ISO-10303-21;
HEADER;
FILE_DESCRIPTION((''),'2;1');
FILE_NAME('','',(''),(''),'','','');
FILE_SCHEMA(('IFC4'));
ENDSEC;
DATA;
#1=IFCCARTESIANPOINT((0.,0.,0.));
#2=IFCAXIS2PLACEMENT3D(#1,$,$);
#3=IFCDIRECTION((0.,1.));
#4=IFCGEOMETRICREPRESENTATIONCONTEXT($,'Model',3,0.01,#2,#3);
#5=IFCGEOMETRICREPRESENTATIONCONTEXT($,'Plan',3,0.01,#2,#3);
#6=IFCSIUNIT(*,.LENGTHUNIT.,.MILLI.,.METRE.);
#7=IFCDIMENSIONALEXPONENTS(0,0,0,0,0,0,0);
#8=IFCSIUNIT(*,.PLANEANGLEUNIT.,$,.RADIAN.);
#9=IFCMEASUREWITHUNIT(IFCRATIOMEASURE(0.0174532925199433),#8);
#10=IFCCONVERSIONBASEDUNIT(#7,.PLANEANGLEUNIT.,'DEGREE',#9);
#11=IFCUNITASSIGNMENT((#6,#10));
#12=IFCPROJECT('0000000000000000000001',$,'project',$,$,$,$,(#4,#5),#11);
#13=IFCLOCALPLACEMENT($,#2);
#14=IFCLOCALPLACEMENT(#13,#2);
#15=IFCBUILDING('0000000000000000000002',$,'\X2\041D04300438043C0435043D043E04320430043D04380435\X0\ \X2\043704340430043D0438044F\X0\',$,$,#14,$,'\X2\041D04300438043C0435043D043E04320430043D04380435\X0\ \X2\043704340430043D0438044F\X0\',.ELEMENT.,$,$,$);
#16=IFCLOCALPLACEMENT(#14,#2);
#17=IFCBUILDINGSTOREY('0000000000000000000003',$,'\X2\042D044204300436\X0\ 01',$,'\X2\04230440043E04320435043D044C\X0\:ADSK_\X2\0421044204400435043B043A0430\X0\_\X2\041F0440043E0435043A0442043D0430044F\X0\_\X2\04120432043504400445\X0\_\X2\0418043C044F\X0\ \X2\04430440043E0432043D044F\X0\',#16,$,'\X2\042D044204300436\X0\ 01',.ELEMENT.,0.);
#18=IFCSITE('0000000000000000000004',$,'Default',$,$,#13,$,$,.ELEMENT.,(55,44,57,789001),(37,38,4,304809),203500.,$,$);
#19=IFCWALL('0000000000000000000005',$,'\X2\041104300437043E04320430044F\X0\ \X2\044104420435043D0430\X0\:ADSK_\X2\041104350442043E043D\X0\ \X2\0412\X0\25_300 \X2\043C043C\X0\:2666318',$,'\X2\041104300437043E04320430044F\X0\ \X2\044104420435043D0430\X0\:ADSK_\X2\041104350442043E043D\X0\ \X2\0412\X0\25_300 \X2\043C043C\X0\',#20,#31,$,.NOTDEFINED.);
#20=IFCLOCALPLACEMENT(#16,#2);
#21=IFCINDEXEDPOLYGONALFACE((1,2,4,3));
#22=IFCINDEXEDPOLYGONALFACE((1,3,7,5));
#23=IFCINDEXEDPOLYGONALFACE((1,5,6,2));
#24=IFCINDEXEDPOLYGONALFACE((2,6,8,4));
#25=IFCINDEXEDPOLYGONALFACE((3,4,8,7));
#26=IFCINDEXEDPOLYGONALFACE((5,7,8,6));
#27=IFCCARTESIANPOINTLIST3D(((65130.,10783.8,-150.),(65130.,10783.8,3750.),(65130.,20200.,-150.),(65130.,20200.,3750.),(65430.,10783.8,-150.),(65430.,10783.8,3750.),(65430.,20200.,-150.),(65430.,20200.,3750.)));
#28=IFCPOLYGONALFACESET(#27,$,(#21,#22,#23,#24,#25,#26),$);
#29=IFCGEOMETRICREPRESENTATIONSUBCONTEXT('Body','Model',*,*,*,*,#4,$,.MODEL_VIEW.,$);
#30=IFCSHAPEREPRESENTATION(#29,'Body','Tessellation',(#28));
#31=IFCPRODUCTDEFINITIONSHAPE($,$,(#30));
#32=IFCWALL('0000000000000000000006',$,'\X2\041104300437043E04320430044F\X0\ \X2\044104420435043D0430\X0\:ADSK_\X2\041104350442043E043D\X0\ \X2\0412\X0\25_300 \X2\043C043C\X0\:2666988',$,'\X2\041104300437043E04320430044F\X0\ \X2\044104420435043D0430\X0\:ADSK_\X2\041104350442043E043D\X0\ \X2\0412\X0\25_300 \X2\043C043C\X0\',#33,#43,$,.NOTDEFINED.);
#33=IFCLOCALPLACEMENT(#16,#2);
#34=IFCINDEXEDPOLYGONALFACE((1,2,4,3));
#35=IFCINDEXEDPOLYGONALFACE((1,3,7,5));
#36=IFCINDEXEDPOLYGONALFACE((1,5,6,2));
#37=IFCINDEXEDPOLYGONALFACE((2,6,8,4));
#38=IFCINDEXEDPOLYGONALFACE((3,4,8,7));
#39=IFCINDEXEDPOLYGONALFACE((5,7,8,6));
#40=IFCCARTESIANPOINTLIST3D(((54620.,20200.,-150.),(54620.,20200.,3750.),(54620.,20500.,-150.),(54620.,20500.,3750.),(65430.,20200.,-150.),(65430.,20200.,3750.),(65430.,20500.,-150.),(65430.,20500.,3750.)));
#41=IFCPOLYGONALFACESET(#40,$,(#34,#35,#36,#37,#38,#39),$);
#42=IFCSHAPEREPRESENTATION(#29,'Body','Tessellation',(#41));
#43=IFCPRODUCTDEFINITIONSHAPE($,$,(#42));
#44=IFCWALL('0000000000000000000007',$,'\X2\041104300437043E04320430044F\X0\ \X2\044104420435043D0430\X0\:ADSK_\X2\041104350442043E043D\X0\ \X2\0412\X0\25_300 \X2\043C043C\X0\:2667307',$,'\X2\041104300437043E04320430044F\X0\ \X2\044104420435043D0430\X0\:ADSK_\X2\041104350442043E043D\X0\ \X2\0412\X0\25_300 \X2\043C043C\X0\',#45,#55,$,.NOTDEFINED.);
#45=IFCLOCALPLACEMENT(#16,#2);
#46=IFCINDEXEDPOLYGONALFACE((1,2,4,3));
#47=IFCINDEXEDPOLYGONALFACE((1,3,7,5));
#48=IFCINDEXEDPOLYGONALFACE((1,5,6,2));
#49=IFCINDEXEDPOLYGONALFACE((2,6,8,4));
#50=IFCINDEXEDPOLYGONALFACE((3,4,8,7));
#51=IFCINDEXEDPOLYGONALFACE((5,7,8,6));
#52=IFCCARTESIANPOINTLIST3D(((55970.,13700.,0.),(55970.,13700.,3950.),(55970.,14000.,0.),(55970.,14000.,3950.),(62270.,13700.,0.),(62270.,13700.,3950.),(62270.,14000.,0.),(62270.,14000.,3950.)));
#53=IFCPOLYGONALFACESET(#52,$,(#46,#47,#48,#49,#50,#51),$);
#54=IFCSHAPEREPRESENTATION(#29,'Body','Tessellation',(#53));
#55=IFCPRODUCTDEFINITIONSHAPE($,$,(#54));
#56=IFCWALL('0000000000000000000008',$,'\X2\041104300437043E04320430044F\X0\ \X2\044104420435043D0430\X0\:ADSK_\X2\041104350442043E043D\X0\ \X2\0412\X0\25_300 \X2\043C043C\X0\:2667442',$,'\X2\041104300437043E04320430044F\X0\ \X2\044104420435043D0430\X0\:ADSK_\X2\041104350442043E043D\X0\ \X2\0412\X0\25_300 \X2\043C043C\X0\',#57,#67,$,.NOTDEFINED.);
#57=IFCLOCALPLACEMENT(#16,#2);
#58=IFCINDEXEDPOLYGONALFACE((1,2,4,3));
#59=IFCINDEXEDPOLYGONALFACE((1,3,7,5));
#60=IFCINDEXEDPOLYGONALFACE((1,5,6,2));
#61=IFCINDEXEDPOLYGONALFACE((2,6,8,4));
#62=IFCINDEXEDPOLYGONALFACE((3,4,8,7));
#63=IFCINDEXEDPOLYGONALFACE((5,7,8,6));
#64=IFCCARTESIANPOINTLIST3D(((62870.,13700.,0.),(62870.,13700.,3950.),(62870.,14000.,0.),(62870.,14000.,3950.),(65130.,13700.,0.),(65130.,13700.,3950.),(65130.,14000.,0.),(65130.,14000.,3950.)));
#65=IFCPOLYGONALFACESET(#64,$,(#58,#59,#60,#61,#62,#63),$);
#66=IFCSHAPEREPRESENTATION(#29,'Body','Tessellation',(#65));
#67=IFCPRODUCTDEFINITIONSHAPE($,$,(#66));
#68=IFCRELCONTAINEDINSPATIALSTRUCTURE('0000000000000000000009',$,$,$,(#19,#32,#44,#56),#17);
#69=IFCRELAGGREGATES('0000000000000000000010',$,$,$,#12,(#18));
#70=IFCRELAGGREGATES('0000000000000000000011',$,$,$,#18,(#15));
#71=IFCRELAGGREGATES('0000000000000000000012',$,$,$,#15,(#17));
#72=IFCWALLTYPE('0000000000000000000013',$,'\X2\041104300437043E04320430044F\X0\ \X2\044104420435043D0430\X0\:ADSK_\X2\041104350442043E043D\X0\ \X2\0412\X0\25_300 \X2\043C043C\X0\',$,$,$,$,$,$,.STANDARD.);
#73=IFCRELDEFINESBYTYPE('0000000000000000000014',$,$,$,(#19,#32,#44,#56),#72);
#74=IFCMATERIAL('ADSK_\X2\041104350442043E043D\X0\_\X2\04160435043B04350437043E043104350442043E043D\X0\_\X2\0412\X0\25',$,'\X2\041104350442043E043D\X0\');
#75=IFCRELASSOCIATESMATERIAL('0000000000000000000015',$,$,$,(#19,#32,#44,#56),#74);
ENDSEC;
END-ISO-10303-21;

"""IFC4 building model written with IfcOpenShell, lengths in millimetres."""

from ifc_helpers import new_model, entity, si_unit, converted_unit, direction, frame, origin, place, context, subcontext, project, spatial, indexed_curve, outline, extrude, material, type_object, element, save


model = new_model("IFC4")

# Units and contexts
model_context = context("Model", 3, precision=0.01, world=origin(), true_north=direction((0.0, 1.0)))
plan_context = context("Plan", 3, precision=0.01, world=origin(), true_north=direction((0.0, 1.0)))
body_context = subcontext(model_context, "Body", "Model", "MODEL_VIEW")
ifc_project = project(units=[si_unit("LENGTHUNIT", "METRE", prefix="MILLI"), converted_unit("PLANEANGLEUNIT", "DEGREE", entity("IfcRatioMeasure", 0.0174532925199433), si_unit("PLANEANGLEUNIT", "RADIAN"), dimensions=[0, 0, 0, 0, 0, 0, 0])], contexts=[model_context, plan_context])

# Site, building, storey
site_placement = place(None, origin())
site = spatial("IfcSite", under=ifc_project, at=site_placement, Name="Default", CompositionType="ELEMENT", RefLatitude=(55, 44, 57, 789001), RefLongitude=(37, 38, 4, 304809), RefElevation=203500.0)
building_placement = place(site_placement, origin())
building = spatial("IfcBuilding", under=site, at=building_placement, Name="Наименование здания", LongName="Наименование здания", CompositionType="ELEMENT")
storey_placement = place(building_placement, origin())
storey = spatial("IfcBuildingStorey", under=building, at=storey_placement, Name="Этаж 01", ObjectType="Уровень:ADSK_Стрелка_Проектная_Вверх_Имя уровня", LongName="Этаж 01", CompositionType="ELEMENT", Elevation=0.0)

# Walls
ifc_material = material(Name="ADSK_Бетон_Железобетон_В25", Category="Бетон")
wall_type_1 = type_object("IfcWallType", Name="Базовая стена:ADSK_Бетон В25_300 мм", PredefinedType="STANDARD")
wall_1_placement = place(storey_placement, frame((65280.0, 10783.8, -150.0), z_axis=(0.0, 0.0, 1.0), x_axis=(0.0, 1.0, 0.0)))
element("IfcWall", 1, at=wall_1_placement, inside=storey, type_object=wall_type_1, material=ifc_material, Name="Базовая стена:ADSK_Бетон В25_300 мм:2666318", ObjectType="Базовая стена:ADSK_Бетон В25_300 мм", PredefinedType="NOTDEFINED", context=body_context, shape_type="SweptSolid", body=[
    extrude(outline(indexed_curve([(9416.2, 150.0), (0.0, 150.0), (0.0, -150.0), (9416.2, -150.0), (9416.2, 150.0)], self_intersect=False)), origin(), (0.0, 0.0, 1.0), 3900.0),
])
wall_2_placement = place(storey_placement, frame((65430.0, 20350.0, -150.0), z_axis=(0.0, 0.0, 1.0), x_axis=(-1.0, 0.0, 0.0)))
element("IfcWall", 2, at=wall_2_placement, inside=storey, type_object=wall_type_1, material=ifc_material, Name="Базовая стена:ADSK_Бетон В25_300 мм:2666988", ObjectType="Базовая стена:ADSK_Бетон В25_300 мм", PredefinedType="NOTDEFINED", context=body_context, shape_type="SweptSolid", body=[
    extrude(outline(indexed_curve([(10810.0, 150.0), (0.0, 150.0), (0.0, -150.0), (10810.0, -150.0), (10810.0, 150.0)], self_intersect=False)), origin(), (0.0, 0.0, 1.0), 3900.0),
])
wall_3_placement = place(storey_placement, frame((55970.0, 13850.0, 0.0)))
element("IfcWall", 3, at=wall_3_placement, inside=storey, type_object=wall_type_1, material=ifc_material, Name="Базовая стена:ADSK_Бетон В25_300 мм:2667307", ObjectType="Базовая стена:ADSK_Бетон В25_300 мм", PredefinedType="NOTDEFINED", context=body_context, shape_type="SweptSolid", body=[
    extrude(outline(indexed_curve([(6300.0, 150.0), (0.0, 150.0), (0.0, -150.0), (6300.0, -150.0), (6300.0, 150.0)], self_intersect=False)), origin(), (0.0, 0.0, 1.0), 3950.0),
])
wall_4_placement = place(storey_placement, frame((62870.0, 13850.0, 0.0)))
element("IfcWall", 4, at=wall_4_placement, inside=storey, type_object=wall_type_1, material=ifc_material, Name="Базовая стена:ADSK_Бетон В25_300 мм:2667442", ObjectType="Базовая стена:ADSK_Бетон В25_300 мм", PredefinedType="NOTDEFINED", context=body_context, shape_type="SweptSolid", body=[
    extrude(outline(indexed_curve([(2260.0, 150.0), (0.0, 150.0), (0.0, -150.0), (2260.0, -150.0), (2260.0, 150.0)], self_intersect=False)), origin(), (0.0, 0.0, 1.0), 3950.0),
])

save(model, "model.ifc")
